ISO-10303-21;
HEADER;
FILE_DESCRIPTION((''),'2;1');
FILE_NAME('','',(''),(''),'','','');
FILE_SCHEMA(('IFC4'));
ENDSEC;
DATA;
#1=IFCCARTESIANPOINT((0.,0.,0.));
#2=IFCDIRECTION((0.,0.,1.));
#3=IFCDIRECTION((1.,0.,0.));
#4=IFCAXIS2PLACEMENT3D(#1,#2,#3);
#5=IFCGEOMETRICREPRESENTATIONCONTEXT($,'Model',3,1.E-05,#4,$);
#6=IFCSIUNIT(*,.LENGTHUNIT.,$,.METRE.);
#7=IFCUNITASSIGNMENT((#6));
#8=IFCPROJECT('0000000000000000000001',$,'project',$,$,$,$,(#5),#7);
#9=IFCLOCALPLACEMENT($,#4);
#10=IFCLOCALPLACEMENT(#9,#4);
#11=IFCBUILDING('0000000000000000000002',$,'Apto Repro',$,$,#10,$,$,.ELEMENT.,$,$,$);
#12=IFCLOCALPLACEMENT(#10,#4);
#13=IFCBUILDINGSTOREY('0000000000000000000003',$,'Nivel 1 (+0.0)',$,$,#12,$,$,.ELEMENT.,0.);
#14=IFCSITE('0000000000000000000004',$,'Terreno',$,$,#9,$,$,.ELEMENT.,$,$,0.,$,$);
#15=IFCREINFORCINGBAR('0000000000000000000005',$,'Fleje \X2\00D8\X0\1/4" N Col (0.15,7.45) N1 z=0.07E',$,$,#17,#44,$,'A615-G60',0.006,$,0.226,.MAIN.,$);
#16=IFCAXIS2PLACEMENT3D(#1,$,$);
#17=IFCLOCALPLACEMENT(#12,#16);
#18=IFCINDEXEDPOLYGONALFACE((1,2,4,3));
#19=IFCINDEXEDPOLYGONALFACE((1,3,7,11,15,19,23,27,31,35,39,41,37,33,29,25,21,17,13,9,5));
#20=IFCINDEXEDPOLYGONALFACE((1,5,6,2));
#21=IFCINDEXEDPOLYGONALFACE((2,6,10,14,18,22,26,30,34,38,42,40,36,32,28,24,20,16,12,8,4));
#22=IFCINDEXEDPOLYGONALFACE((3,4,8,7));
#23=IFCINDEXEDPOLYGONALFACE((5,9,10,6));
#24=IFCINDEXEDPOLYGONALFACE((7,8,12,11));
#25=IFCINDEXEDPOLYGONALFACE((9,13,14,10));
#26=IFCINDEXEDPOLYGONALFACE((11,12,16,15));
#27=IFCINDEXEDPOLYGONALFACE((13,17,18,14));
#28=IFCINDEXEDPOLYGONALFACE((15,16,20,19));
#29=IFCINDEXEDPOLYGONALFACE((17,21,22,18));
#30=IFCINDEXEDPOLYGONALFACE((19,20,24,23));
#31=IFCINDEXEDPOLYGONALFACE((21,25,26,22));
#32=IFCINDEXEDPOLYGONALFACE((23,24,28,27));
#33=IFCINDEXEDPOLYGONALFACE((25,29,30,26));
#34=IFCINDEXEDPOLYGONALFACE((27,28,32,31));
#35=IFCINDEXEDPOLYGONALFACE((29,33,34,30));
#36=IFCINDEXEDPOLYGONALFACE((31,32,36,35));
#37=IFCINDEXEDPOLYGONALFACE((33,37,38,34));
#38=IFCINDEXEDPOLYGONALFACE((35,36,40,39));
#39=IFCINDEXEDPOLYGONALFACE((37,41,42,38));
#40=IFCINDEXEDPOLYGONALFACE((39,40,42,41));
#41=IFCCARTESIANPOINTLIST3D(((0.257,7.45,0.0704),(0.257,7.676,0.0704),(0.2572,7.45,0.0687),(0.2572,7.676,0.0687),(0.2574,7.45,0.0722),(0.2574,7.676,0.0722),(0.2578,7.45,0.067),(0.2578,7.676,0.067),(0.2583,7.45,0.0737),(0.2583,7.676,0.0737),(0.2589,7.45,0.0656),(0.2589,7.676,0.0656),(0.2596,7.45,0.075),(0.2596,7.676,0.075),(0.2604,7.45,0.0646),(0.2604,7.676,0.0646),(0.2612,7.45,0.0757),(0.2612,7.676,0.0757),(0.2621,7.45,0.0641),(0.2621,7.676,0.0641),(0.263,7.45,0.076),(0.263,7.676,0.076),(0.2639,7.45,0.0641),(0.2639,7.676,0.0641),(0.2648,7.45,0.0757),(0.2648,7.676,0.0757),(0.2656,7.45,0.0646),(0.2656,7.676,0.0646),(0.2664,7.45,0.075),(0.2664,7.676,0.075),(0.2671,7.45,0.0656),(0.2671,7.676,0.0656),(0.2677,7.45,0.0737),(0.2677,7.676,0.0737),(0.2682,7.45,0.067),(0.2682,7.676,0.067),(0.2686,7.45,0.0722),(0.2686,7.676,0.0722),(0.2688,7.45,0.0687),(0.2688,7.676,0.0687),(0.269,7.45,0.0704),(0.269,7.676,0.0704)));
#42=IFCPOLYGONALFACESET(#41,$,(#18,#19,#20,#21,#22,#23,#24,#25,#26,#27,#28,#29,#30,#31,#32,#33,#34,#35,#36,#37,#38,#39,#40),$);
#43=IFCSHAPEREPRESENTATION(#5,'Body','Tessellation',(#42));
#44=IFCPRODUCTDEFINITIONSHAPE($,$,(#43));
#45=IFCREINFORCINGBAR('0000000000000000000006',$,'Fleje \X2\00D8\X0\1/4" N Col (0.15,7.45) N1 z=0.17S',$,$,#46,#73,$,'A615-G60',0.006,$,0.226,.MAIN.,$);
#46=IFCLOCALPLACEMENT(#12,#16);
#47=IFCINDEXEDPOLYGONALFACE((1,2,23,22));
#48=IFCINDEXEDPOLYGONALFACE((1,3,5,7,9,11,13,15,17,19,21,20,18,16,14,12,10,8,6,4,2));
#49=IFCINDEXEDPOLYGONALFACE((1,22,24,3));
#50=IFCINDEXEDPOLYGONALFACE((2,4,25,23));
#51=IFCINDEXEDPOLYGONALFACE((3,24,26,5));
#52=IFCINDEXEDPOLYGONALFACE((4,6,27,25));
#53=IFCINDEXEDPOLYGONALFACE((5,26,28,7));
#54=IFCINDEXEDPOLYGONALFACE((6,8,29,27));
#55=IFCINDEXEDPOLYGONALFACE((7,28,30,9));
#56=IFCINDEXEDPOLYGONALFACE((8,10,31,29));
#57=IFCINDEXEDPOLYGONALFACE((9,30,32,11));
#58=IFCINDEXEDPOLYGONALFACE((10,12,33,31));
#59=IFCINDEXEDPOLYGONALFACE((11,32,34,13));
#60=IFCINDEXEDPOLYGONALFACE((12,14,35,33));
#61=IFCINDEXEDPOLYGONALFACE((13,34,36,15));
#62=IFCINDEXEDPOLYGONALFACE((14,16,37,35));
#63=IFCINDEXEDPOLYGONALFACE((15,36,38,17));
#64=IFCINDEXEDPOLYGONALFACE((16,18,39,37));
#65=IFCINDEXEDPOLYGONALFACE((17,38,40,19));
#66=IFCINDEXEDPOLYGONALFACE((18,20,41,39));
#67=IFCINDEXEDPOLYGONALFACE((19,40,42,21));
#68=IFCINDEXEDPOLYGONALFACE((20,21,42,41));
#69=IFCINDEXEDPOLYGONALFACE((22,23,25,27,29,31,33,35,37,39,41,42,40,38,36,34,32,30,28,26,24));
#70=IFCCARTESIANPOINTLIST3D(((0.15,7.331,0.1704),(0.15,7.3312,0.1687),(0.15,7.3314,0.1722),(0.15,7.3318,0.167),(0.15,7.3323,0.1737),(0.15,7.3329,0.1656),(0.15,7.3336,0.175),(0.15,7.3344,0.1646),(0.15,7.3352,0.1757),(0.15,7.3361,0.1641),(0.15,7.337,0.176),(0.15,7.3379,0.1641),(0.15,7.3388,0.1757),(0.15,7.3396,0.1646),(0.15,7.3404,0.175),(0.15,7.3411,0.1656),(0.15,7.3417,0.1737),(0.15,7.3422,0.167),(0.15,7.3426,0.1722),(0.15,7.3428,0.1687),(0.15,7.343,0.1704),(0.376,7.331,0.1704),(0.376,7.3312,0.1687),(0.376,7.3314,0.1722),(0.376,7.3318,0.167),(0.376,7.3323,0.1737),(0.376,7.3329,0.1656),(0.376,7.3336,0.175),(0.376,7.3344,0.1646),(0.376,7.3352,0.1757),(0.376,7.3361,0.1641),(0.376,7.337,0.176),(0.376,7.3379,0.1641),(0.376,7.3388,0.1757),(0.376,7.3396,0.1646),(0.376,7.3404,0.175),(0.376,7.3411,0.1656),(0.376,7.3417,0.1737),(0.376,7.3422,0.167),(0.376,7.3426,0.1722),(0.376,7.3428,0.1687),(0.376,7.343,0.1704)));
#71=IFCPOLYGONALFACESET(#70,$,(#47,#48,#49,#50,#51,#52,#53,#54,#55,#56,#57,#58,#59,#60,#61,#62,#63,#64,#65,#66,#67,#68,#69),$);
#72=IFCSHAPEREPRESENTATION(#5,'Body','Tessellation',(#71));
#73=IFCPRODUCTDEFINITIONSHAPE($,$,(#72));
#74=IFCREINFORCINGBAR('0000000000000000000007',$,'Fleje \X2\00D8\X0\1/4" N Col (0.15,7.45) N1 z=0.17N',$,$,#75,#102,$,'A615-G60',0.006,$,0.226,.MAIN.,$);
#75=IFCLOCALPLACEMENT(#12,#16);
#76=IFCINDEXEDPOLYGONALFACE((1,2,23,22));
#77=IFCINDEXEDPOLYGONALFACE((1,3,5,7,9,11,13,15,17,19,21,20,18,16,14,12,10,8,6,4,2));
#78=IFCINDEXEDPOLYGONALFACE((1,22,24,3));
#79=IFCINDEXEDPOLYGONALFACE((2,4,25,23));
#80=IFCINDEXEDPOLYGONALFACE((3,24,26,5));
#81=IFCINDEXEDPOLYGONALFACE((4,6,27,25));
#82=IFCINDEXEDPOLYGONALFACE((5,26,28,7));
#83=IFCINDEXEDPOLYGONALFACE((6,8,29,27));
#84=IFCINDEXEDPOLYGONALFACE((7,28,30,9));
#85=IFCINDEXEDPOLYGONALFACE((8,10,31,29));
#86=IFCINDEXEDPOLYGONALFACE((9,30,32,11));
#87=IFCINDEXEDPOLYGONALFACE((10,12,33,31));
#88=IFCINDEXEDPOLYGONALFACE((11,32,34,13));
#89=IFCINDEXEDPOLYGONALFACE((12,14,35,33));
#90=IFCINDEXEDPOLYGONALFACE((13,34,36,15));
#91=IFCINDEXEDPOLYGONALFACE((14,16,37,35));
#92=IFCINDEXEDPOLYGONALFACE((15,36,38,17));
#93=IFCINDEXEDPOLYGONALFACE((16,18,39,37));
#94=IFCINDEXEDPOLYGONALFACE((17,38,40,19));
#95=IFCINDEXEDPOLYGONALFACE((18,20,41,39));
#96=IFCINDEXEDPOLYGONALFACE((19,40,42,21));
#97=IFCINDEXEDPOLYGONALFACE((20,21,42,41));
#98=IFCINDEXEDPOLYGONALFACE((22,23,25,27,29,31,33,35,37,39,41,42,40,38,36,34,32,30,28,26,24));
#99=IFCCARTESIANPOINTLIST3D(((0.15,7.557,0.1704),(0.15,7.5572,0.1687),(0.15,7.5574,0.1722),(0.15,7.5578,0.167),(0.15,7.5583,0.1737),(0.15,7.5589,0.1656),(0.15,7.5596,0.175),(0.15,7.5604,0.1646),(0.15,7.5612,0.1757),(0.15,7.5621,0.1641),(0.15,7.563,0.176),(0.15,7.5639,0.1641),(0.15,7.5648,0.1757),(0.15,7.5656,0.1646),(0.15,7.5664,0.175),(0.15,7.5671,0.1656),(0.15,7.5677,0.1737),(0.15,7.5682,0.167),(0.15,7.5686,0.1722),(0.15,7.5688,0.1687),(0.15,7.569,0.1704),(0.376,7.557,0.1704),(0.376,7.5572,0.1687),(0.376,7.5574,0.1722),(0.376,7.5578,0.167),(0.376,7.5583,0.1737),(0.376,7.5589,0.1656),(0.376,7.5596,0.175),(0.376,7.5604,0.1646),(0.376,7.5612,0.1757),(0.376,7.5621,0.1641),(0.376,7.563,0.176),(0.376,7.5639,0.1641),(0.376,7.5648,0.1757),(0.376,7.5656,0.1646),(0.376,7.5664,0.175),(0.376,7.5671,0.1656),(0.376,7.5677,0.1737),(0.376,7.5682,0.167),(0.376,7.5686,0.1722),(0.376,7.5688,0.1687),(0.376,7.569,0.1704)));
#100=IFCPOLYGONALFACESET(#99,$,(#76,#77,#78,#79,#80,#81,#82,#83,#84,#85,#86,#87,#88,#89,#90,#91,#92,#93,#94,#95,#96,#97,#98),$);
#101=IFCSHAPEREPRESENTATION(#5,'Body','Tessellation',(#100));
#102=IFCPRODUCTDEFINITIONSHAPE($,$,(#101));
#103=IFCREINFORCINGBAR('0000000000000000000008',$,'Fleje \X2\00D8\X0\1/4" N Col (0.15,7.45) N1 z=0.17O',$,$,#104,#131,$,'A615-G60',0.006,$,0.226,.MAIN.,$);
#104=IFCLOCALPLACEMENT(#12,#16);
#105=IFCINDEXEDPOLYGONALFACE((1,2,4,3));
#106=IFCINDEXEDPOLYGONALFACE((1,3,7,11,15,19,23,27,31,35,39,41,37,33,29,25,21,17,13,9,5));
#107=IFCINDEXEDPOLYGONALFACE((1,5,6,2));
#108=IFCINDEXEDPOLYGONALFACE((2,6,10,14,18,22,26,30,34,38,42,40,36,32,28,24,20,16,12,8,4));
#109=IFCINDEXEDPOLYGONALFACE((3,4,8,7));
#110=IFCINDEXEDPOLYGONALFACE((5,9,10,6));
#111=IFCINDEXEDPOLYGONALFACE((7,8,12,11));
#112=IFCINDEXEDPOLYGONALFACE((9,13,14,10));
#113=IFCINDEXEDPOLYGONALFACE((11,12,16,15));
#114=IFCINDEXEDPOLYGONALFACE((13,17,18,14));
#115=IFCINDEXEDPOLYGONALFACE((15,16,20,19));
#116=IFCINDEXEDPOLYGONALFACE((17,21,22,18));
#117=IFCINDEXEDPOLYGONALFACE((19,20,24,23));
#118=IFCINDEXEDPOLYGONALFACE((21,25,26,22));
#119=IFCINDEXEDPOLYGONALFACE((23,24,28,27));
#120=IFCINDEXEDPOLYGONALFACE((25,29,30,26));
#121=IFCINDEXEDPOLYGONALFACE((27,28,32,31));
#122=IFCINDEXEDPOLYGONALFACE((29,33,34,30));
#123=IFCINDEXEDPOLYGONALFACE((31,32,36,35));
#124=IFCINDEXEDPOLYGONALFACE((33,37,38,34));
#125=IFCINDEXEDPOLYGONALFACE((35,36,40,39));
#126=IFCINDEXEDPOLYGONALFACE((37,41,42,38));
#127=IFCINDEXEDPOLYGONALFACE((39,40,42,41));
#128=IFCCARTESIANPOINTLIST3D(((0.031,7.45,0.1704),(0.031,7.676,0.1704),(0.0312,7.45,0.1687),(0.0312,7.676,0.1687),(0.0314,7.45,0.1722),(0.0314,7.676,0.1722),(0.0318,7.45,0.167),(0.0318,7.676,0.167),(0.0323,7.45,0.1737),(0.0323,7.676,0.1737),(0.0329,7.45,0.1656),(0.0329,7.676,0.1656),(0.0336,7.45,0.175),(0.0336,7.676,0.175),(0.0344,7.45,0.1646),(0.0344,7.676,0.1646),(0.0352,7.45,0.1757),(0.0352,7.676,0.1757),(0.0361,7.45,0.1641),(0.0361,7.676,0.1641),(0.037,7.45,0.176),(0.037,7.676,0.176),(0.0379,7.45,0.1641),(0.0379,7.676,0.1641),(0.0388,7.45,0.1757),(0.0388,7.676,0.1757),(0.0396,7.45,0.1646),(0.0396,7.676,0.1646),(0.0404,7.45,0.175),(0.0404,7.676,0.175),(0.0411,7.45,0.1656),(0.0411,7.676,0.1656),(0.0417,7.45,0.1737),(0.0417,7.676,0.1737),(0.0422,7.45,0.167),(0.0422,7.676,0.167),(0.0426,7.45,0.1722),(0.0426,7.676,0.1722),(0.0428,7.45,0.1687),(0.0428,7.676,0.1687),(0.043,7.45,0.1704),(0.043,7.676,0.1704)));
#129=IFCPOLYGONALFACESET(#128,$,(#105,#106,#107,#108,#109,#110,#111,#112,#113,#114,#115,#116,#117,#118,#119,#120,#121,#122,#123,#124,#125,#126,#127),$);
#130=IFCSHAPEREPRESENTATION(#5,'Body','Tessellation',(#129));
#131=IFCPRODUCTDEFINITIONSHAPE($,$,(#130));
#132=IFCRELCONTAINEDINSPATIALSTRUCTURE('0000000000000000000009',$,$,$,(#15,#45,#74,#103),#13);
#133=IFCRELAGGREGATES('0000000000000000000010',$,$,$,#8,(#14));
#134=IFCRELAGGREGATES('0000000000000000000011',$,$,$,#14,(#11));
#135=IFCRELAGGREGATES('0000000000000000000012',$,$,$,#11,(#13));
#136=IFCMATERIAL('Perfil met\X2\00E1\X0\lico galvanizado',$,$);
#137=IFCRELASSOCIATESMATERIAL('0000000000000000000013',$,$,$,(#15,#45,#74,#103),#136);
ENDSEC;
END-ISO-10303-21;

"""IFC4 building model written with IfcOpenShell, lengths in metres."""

from ifc_helpers import new_model, si_unit, frame, origin_with_axes, origin_2d_with_axis, place, context, project, spatial, circle, extrude, material, element, save


model = new_model("IFC4")

# Units and contexts
model_context = context("Model", 3, precision=1e-05, world=origin_with_axes())
ifc_project = project(units=[si_unit("LENGTHUNIT", "METRE")], contexts=[model_context])

# Site, building, storey
site_placement = place(None, origin_with_axes())
site = spatial("IfcSite", under=ifc_project, at=site_placement, Name="Terreno", CompositionType="ELEMENT", RefElevation=0.0)
building_placement = place(site_placement, origin_with_axes())
building = spatial("IfcBuilding", under=site, at=building_placement, Name="Apto Repro", CompositionType="ELEMENT")
storey_placement = place(building_placement, origin_with_axes())
storey = spatial("IfcBuildingStorey", under=building, at=storey_placement, Name="Nivel 1 (+0.0)", CompositionType="ELEMENT", Elevation=0.0)

# Reinforcing bars
ifc_material = material(Name="Perfil metálico galvanizado")
reinforcing_bar_1_placement = place(storey_placement, origin_with_axes())
element("IfcReinforcingBar", 1, at=reinforcing_bar_1_placement, inside=storey, material=ifc_material, Name="Fleje Ø1/4\" N Col (0.15,7.45) N1 z=0.07E", SteelGrade="A615-G60", BarLength=0.226, NominalDiameter=0.006, PredefinedType="MAIN", context=model_context, shape_type="SweptSolid", body=[
    extrude(circle(Radius=0.006, at=origin_2d_with_axis()), frame((0.263, 7.45, 0.07), z_axis=(0.0, 1.0, 0.0), x_axis=(0.0, 0.0, 1.0)), (0.0, 0.0, 1.0), 0.226),
])
reinforcing_bar_2_placement = place(storey_placement, origin_with_axes())
element("IfcReinforcingBar", 2, at=reinforcing_bar_2_placement, inside=storey, material=ifc_material, Name="Fleje Ø1/4\" N Col (0.15,7.45) N1 z=0.17S", SteelGrade="A615-G60", BarLength=0.226, NominalDiameter=0.006, PredefinedType="MAIN", context=model_context, shape_type="SweptSolid", body=[
    extrude(circle(Radius=0.006, at=origin_2d_with_axis()), frame((0.15, 7.337, 0.17), z_axis=(1.0, 0.0, 0.0), x_axis=(0.0, 0.0, 1.0)), (0.0, 0.0, 1.0), 0.226),
])
reinforcing_bar_3_placement = place(storey_placement, origin_with_axes())
element("IfcReinforcingBar", 3, at=reinforcing_bar_3_placement, inside=storey, material=ifc_material, Name="Fleje Ø1/4\" N Col (0.15,7.45) N1 z=0.17N", SteelGrade="A615-G60", BarLength=0.226, NominalDiameter=0.006, PredefinedType="MAIN", context=model_context, shape_type="SweptSolid", body=[
    extrude(circle(Radius=0.006, at=origin_2d_with_axis()), frame((0.15, 7.563, 0.17), z_axis=(1.0, 0.0, 0.0), x_axis=(0.0, 0.0, 1.0)), (0.0, 0.0, 1.0), 0.226),
])
reinforcing_bar_4_placement = place(storey_placement, origin_with_axes())
element("IfcReinforcingBar", 4, at=reinforcing_bar_4_placement, inside=storey, material=ifc_material, Name="Fleje Ø1/4\" N Col (0.15,7.45) N1 z=0.17O", SteelGrade="A615-G60", BarLength=0.226, NominalDiameter=0.006, PredefinedType="MAIN", context=model_context, shape_type="SweptSolid", body=[
    extrude(circle(Radius=0.006, at=origin_2d_with_axis()), frame((0.037, 7.45, 0.17), z_axis=(0.0, 1.0, 0.0), x_axis=(0.0, 0.0, 1.0)), (0.0, 0.0, 1.0), 0.226),
])

save(model, "model.ifc")
